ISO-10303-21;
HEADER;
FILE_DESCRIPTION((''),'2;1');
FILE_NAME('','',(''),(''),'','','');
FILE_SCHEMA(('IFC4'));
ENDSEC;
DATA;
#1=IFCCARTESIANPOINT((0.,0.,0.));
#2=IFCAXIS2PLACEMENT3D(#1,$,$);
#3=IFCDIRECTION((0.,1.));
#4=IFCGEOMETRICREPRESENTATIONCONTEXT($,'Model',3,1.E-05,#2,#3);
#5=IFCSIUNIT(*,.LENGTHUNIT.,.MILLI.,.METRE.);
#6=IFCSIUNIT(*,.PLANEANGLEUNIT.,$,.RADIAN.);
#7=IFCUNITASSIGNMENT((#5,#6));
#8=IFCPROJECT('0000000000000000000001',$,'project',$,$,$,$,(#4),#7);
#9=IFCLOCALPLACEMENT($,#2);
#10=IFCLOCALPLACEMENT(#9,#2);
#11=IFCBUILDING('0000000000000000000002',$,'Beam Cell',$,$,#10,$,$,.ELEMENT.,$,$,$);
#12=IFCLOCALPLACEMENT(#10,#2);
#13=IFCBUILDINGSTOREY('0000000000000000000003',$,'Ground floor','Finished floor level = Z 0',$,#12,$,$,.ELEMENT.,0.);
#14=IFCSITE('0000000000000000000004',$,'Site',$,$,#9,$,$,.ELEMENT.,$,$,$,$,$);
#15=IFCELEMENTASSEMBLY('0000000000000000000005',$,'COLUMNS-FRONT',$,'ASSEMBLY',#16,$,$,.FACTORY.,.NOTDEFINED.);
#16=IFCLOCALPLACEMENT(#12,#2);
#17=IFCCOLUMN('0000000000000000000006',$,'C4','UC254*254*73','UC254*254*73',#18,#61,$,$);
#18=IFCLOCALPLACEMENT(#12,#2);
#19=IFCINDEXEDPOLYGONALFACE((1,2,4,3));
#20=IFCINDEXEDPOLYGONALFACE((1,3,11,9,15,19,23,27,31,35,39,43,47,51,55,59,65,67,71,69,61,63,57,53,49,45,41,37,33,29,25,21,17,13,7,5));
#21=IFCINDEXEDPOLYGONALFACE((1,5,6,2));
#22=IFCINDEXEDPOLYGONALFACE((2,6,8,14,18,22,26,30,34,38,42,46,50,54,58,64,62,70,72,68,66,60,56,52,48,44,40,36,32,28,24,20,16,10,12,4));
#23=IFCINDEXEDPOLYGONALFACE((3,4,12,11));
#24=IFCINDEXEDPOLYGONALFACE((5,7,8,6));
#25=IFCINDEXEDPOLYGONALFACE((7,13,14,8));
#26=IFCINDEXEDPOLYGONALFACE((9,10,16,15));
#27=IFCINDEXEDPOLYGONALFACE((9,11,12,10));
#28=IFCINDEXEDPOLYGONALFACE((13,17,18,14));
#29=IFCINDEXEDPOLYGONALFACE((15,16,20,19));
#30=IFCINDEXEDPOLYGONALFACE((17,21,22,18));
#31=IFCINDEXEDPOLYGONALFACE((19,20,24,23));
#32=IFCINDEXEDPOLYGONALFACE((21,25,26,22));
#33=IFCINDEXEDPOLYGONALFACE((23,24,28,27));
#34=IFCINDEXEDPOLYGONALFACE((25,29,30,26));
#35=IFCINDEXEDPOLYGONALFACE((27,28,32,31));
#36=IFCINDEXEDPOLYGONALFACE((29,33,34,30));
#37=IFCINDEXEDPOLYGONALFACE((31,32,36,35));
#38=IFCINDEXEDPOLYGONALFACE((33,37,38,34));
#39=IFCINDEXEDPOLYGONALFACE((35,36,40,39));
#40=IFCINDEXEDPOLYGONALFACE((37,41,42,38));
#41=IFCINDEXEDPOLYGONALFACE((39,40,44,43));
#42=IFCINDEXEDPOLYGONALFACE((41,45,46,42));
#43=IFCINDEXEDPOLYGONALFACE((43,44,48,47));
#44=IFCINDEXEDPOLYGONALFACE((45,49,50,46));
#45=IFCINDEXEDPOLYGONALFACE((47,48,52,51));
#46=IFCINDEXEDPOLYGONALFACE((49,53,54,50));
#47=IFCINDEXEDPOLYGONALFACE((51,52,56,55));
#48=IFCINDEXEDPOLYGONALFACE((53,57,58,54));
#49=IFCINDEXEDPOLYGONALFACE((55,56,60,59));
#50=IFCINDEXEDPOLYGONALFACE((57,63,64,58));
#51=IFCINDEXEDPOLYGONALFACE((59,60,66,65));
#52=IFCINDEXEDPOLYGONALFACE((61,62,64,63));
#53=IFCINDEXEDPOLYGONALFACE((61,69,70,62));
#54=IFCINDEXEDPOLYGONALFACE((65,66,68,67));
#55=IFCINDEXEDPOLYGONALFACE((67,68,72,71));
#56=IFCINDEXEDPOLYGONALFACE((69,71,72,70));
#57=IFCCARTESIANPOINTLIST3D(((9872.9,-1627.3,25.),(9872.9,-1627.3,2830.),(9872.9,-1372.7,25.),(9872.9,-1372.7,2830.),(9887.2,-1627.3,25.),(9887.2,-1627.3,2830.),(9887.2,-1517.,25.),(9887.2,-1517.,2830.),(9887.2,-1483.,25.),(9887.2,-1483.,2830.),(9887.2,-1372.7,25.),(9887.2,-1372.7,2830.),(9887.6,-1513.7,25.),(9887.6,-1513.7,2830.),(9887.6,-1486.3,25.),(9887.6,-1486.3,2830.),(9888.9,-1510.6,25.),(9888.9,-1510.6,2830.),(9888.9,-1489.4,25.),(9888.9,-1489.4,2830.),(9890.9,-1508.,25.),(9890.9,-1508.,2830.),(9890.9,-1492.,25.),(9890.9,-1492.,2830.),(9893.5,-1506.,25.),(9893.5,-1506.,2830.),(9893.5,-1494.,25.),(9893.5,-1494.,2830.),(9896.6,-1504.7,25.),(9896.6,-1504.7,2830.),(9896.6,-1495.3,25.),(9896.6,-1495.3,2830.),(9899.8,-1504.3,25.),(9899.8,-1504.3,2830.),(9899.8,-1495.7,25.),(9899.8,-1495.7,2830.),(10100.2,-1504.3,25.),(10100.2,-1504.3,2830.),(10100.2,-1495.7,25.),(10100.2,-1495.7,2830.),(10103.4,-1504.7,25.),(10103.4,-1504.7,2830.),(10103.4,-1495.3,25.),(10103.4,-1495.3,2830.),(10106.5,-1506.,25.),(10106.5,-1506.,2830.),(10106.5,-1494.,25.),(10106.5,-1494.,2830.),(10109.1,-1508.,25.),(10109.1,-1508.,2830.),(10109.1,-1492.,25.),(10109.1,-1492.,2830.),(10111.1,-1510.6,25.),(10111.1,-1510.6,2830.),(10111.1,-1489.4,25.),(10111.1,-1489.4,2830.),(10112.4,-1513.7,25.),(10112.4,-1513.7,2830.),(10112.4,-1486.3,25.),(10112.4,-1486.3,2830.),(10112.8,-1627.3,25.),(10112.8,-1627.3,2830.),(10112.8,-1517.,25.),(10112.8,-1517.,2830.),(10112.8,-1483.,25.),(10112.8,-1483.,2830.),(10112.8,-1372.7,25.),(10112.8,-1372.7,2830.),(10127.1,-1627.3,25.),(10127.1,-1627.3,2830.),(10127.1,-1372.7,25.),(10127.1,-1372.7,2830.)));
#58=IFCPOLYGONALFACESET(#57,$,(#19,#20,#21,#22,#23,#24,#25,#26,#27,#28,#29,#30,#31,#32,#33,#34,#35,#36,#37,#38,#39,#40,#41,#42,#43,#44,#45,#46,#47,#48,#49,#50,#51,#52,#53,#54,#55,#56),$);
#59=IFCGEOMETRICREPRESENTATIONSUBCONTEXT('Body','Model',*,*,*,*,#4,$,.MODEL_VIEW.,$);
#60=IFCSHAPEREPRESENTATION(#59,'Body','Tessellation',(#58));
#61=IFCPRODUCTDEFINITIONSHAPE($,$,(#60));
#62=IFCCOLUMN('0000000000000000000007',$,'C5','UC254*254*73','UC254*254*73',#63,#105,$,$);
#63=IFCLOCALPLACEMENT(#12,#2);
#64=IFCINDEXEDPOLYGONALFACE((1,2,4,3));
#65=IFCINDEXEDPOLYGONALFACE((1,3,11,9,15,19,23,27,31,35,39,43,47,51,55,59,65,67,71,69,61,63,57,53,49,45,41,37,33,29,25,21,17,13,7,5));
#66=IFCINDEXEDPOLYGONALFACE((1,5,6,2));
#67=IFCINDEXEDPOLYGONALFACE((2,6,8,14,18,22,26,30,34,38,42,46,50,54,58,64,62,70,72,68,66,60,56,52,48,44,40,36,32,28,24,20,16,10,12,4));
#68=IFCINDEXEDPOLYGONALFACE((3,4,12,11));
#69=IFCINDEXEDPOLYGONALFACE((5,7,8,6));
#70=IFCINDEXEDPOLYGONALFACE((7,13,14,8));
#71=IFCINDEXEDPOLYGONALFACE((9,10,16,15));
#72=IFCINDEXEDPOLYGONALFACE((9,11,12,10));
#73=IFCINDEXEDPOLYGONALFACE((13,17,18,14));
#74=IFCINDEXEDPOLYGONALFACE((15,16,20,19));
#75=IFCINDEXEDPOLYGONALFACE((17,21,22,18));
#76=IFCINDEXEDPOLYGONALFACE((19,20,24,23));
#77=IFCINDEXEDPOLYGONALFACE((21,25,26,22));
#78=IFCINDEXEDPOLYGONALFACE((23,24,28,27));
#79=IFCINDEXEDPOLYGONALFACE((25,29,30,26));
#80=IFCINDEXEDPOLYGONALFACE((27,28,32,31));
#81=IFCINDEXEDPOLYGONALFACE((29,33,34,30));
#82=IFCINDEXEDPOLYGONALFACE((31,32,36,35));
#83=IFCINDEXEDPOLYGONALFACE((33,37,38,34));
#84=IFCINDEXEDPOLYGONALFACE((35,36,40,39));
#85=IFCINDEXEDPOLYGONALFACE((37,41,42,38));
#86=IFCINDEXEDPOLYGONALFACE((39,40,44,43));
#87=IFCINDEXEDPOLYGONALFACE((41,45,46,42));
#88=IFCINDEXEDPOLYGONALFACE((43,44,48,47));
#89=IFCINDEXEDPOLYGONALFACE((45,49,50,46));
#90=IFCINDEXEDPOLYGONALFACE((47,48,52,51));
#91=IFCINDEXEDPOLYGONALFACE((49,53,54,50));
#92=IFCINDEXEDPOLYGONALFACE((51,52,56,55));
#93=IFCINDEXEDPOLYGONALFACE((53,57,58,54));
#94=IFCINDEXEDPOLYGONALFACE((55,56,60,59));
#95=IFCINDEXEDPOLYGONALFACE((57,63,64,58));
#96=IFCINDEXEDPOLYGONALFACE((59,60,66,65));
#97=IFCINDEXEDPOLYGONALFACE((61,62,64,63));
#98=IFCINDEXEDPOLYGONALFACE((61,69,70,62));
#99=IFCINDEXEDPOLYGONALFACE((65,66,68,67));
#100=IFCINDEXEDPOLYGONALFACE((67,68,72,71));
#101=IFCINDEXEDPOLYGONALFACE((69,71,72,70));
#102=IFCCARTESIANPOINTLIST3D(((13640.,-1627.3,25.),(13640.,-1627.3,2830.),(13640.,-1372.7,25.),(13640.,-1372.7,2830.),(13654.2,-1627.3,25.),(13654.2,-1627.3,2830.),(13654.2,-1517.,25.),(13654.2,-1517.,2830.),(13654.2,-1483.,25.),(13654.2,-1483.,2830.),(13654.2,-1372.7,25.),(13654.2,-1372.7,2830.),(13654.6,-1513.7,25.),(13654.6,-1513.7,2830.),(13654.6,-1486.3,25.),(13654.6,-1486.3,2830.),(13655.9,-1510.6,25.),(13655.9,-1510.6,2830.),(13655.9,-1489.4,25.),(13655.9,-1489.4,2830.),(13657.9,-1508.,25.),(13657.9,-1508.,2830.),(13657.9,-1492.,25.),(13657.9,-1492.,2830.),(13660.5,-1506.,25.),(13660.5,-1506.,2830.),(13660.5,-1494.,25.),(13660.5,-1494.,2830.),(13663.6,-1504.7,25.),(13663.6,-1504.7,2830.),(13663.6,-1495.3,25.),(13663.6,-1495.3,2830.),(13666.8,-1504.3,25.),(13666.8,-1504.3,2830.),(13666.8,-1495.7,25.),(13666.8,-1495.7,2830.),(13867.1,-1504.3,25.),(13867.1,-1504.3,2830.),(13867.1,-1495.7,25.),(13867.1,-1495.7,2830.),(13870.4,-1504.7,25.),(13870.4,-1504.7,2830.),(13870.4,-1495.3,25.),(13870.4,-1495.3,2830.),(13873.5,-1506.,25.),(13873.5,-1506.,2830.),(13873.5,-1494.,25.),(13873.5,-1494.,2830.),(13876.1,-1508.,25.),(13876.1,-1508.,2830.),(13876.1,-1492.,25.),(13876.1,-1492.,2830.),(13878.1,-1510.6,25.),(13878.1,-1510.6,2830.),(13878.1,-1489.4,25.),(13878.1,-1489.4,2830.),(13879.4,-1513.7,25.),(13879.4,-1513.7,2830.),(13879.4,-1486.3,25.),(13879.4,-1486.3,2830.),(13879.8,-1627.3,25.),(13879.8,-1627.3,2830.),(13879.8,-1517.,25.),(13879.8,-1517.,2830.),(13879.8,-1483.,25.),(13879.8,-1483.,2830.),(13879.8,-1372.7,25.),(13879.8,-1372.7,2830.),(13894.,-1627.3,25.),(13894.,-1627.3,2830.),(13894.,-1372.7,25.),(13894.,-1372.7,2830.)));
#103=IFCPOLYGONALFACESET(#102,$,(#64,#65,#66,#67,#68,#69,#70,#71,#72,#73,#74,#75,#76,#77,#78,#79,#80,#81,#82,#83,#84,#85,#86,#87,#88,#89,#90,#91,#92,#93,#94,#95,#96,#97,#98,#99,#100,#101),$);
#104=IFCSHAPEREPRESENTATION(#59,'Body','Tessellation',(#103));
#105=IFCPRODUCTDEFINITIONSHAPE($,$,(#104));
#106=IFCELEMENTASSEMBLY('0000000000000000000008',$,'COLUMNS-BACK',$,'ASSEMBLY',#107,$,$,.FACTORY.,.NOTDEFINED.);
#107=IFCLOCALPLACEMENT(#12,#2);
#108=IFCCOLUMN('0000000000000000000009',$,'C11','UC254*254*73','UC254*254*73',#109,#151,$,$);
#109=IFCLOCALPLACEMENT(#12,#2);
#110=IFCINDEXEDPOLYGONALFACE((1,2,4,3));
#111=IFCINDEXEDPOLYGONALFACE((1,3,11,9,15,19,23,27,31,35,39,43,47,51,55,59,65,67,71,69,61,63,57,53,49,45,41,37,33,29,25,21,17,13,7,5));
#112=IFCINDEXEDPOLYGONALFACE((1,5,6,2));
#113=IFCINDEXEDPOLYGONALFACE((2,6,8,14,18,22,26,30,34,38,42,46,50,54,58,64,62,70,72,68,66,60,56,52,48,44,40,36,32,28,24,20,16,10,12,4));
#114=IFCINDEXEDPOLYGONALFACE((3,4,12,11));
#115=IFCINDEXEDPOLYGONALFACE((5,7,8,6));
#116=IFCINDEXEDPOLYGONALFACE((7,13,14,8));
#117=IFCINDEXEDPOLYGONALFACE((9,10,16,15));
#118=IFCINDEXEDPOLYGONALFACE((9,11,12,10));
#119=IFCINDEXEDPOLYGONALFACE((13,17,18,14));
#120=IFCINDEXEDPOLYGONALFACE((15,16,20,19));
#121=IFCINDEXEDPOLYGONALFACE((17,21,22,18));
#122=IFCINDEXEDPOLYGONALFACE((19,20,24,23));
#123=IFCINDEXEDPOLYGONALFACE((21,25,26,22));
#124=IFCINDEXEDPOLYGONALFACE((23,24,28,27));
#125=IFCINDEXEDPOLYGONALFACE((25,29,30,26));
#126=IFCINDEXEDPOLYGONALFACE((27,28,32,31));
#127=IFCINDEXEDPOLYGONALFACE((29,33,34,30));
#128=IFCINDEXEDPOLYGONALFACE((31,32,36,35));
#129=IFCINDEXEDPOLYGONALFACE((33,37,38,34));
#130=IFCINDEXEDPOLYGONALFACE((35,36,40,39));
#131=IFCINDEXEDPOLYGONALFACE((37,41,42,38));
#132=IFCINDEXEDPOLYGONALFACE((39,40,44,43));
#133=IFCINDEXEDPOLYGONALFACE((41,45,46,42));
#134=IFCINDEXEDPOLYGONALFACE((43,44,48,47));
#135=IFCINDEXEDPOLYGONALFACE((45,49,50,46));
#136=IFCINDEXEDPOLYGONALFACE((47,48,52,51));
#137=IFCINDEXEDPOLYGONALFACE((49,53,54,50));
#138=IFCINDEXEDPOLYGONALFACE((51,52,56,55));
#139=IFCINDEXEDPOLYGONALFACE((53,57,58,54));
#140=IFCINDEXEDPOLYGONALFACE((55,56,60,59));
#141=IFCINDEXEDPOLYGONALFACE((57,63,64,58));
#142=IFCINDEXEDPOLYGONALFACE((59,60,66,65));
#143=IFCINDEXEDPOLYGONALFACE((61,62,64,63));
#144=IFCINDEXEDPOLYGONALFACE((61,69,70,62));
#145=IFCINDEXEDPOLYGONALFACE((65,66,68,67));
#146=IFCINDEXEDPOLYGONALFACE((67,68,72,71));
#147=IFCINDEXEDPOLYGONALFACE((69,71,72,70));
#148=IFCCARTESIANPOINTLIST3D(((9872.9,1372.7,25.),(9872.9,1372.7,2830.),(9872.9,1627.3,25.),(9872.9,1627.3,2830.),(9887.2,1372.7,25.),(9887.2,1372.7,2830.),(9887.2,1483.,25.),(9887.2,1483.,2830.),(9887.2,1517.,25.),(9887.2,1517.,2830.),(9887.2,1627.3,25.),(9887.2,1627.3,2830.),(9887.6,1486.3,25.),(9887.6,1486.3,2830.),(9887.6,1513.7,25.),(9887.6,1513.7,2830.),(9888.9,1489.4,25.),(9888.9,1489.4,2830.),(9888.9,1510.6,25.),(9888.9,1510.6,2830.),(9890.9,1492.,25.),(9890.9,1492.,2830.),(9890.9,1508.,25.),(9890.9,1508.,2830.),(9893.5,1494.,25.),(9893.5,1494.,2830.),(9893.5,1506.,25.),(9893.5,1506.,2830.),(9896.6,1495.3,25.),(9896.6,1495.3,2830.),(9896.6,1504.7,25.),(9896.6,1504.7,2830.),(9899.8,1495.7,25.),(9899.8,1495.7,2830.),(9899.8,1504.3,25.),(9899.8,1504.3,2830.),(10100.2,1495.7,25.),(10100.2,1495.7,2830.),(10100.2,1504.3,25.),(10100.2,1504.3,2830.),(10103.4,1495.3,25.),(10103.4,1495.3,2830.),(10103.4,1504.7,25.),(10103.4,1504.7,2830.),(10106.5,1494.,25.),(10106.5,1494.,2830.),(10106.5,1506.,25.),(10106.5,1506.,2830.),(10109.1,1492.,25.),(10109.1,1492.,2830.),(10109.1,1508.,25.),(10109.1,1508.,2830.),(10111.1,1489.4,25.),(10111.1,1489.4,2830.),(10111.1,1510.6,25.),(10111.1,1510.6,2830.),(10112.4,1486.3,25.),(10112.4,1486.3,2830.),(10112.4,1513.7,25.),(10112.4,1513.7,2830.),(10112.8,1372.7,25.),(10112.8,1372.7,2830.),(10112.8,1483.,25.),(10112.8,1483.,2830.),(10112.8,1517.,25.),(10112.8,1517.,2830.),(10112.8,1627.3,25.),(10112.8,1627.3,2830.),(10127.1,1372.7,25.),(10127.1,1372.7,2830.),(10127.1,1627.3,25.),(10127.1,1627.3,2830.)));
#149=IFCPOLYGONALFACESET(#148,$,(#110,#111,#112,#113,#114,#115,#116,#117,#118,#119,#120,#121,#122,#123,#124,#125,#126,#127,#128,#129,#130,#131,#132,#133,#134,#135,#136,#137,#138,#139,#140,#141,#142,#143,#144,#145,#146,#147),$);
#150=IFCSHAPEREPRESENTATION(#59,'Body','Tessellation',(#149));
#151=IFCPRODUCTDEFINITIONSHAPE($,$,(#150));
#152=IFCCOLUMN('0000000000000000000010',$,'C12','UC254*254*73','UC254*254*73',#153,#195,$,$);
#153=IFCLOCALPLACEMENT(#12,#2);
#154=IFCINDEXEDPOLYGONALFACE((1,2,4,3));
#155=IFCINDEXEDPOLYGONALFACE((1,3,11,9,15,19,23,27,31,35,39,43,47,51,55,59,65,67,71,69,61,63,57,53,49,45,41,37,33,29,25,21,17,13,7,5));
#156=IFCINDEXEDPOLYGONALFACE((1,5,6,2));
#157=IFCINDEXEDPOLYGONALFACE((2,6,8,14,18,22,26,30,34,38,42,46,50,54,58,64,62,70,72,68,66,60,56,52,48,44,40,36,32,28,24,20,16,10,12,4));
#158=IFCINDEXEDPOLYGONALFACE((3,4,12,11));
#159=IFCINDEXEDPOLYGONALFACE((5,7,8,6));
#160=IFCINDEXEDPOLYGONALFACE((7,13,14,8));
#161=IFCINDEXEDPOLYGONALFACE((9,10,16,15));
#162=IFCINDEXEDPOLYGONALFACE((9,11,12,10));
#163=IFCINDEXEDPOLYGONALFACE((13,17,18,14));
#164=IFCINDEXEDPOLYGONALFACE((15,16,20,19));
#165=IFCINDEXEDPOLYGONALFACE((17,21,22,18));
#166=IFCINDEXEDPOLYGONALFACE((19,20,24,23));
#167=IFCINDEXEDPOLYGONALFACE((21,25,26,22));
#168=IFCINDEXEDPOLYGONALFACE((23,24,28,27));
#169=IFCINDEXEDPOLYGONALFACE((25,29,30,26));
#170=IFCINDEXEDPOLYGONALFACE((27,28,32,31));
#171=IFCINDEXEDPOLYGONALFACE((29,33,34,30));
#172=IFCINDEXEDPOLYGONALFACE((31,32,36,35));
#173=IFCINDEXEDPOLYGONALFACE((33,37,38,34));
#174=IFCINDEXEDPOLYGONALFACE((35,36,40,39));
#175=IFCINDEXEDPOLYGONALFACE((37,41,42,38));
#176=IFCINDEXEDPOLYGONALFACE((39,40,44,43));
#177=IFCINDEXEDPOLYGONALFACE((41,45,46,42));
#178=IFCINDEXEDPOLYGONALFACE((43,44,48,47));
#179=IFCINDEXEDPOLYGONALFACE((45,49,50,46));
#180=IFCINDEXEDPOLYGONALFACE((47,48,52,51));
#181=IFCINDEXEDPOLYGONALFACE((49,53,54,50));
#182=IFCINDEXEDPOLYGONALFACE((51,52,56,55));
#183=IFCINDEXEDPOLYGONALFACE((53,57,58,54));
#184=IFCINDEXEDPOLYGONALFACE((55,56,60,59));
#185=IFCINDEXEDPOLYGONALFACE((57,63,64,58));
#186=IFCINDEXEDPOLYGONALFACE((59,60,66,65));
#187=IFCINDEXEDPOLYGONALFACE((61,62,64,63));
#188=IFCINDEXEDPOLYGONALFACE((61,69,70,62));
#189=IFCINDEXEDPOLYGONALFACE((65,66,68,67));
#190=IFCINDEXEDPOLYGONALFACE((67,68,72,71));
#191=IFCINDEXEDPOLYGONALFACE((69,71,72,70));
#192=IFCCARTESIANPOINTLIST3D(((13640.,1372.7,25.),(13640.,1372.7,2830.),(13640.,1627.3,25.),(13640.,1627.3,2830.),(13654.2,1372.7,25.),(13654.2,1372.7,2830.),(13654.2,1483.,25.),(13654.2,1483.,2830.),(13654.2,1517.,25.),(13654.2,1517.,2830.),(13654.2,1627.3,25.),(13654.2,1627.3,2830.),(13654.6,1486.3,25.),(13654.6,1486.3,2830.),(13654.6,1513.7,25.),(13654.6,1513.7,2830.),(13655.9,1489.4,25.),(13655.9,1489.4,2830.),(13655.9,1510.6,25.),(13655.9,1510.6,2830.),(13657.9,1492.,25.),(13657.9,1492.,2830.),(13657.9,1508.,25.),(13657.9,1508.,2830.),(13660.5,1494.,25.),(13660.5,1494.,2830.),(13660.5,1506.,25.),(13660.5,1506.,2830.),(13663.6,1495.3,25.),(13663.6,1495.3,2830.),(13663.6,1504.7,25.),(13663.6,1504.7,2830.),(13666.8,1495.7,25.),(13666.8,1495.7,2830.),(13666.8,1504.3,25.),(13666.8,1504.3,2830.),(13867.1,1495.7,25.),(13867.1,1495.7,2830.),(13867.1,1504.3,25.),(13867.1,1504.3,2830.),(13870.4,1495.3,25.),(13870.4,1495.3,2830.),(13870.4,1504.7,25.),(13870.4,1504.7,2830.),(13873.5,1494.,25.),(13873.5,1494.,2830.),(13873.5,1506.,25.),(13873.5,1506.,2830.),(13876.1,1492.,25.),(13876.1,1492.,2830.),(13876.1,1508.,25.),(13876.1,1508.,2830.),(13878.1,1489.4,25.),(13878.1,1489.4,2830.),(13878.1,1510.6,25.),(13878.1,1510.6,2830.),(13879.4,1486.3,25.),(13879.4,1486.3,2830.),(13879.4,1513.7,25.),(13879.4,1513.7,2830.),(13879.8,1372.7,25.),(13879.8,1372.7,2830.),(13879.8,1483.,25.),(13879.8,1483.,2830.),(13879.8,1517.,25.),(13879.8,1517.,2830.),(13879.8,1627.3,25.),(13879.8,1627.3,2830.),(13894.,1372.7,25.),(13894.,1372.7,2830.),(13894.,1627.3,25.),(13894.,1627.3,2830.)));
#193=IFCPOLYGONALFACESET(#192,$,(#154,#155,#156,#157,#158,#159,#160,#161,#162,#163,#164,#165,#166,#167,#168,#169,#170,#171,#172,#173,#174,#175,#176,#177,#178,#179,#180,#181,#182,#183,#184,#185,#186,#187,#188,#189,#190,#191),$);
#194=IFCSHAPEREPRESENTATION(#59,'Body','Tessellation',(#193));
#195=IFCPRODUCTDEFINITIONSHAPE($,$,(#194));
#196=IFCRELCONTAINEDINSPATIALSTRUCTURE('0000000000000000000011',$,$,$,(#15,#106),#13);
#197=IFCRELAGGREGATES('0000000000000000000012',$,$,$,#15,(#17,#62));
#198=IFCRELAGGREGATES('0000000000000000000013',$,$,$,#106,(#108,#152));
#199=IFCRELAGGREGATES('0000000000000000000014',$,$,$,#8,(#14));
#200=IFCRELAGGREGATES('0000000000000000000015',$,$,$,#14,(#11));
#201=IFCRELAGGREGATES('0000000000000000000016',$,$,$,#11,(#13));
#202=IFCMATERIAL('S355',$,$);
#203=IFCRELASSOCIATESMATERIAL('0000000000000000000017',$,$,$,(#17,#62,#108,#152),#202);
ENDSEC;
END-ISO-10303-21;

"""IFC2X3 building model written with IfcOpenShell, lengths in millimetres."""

from ifc_helpers import new_model, si_unit, direction, frame, origin, origin_2d, place, context, subcontext, project, spatial, i_section, extrude, material, element, aggregate, save


model = new_model("IFC2X3")

# Units and contexts
model_context = context("Model", 3, precision=1e-05, world=origin(), true_north=direction((0.0, 1.0)))
body_context = subcontext(model_context, "Body", "Model", "MODEL_VIEW")
ifc_project = project(units=[si_unit("LENGTHUNIT", "METRE", prefix="MILLI"), si_unit("PLANEANGLEUNIT", "RADIAN")], contexts=[model_context])

# Site, building, storey
site_placement = place(None, origin())
site = spatial("IfcSite", under=ifc_project, at=site_placement, Name="Site", CompositionType="ELEMENT")
building_placement = place(site_placement, origin())
building = spatial("IfcBuilding", under=site, at=building_placement, Name="Beam Cell", CompositionType="ELEMENT")
storey_placement = place(building_placement, origin())
storey = spatial("IfcBuildingStorey", under=building, at=storey_placement, Name="Ground floor", Description="Finished floor level = Z 0", CompositionType="ELEMENT", Elevation=0.0)

# Element assemblies, columns
assembly_1_placement = place(storey_placement, origin())
assembly_1 = element("IfcElementAssembly", 1, at=assembly_1_placement, inside=storey, Name="COLUMNS-FRONT", ObjectType="ASSEMBLY", AssemblyPlace="FACTORY", PredefinedType="NOTDEFINED")
ifc_material = material(Name="S355")
column_1_placement = place(storey_placement, frame((10000.0, -1500.0, 25.0), z_axis=(0.0, 0.0, 1.0), x_axis=(0.0, 1.0, 0.0)))
column_1 = element("IfcColumn", 2, at=column_1_placement, material=ifc_material, Name="C4", Description="UC254*254*73", ObjectType="UC254*254*73", context=body_context, shape_type="SweptSolid", body=[
    extrude(i_section(OverallWidth=254.6, OverallDepth=254.1, WebThickness=8.6, FlangeThickness=14.2, FilletRadius=12.7, at=origin_2d()), origin(), (0.0, 0.0, 1.0), 2805.0),
])
column_2_placement = place(storey_placement, frame((13767.0, -1500.0, 25.0), z_axis=(0.0, 0.0, 1.0), x_axis=(0.0, 1.0, 0.0)))
column_2 = element("IfcColumn", 3, at=column_2_placement, material=ifc_material, Name="C5", Description="UC254*254*73", ObjectType="UC254*254*73", context=body_context, shape_type="SweptSolid", body=[
    extrude(i_section(OverallWidth=254.6, OverallDepth=254.1, WebThickness=8.6, FlangeThickness=14.2, FilletRadius=12.7, at=origin_2d()), origin(), (0.0, 0.0, 1.0), 2805.0),
])
assembly_2_placement = place(storey_placement, origin())
assembly_2 = element("IfcElementAssembly", 4, at=assembly_2_placement, inside=storey, Name="COLUMNS-BACK", ObjectType="ASSEMBLY", AssemblyPlace="FACTORY", PredefinedType="NOTDEFINED")
column_3_placement = place(storey_placement, frame((10000.0, 1500.0, 25.0), z_axis=(0.0, 0.0, 1.0), x_axis=(0.0, 1.0, 0.0)))
column_3 = element("IfcColumn", 5, at=column_3_placement, material=ifc_material, Name="C11", Description="UC254*254*73", ObjectType="UC254*254*73", context=body_context, shape_type="SweptSolid", body=[
    extrude(i_section(OverallWidth=254.6, OverallDepth=254.1, WebThickness=8.6, FlangeThickness=14.2, FilletRadius=12.7, at=origin_2d()), origin(), (0.0, 0.0, 1.0), 2805.0),
])
column_4_placement = place(storey_placement, frame((13767.0, 1500.0, 25.0), z_axis=(0.0, 0.0, 1.0), x_axis=(0.0, 1.0, 0.0)))
column_4 = element("IfcColumn", 6, at=column_4_placement, material=ifc_material, Name="C12", Description="UC254*254*73", ObjectType="UC254*254*73", context=body_context, shape_type="SweptSolid", body=[
    extrude(i_section(OverallWidth=254.6, OverallDepth=254.1, WebThickness=8.6, FlangeThickness=14.2, FilletRadius=12.7, at=origin_2d()), origin(), (0.0, 0.0, 1.0), 2805.0),
])

aggregate(assembly_1, [column_1, column_2])
aggregate(assembly_2, [column_3, column_4])

save(model, "model.ifc")
